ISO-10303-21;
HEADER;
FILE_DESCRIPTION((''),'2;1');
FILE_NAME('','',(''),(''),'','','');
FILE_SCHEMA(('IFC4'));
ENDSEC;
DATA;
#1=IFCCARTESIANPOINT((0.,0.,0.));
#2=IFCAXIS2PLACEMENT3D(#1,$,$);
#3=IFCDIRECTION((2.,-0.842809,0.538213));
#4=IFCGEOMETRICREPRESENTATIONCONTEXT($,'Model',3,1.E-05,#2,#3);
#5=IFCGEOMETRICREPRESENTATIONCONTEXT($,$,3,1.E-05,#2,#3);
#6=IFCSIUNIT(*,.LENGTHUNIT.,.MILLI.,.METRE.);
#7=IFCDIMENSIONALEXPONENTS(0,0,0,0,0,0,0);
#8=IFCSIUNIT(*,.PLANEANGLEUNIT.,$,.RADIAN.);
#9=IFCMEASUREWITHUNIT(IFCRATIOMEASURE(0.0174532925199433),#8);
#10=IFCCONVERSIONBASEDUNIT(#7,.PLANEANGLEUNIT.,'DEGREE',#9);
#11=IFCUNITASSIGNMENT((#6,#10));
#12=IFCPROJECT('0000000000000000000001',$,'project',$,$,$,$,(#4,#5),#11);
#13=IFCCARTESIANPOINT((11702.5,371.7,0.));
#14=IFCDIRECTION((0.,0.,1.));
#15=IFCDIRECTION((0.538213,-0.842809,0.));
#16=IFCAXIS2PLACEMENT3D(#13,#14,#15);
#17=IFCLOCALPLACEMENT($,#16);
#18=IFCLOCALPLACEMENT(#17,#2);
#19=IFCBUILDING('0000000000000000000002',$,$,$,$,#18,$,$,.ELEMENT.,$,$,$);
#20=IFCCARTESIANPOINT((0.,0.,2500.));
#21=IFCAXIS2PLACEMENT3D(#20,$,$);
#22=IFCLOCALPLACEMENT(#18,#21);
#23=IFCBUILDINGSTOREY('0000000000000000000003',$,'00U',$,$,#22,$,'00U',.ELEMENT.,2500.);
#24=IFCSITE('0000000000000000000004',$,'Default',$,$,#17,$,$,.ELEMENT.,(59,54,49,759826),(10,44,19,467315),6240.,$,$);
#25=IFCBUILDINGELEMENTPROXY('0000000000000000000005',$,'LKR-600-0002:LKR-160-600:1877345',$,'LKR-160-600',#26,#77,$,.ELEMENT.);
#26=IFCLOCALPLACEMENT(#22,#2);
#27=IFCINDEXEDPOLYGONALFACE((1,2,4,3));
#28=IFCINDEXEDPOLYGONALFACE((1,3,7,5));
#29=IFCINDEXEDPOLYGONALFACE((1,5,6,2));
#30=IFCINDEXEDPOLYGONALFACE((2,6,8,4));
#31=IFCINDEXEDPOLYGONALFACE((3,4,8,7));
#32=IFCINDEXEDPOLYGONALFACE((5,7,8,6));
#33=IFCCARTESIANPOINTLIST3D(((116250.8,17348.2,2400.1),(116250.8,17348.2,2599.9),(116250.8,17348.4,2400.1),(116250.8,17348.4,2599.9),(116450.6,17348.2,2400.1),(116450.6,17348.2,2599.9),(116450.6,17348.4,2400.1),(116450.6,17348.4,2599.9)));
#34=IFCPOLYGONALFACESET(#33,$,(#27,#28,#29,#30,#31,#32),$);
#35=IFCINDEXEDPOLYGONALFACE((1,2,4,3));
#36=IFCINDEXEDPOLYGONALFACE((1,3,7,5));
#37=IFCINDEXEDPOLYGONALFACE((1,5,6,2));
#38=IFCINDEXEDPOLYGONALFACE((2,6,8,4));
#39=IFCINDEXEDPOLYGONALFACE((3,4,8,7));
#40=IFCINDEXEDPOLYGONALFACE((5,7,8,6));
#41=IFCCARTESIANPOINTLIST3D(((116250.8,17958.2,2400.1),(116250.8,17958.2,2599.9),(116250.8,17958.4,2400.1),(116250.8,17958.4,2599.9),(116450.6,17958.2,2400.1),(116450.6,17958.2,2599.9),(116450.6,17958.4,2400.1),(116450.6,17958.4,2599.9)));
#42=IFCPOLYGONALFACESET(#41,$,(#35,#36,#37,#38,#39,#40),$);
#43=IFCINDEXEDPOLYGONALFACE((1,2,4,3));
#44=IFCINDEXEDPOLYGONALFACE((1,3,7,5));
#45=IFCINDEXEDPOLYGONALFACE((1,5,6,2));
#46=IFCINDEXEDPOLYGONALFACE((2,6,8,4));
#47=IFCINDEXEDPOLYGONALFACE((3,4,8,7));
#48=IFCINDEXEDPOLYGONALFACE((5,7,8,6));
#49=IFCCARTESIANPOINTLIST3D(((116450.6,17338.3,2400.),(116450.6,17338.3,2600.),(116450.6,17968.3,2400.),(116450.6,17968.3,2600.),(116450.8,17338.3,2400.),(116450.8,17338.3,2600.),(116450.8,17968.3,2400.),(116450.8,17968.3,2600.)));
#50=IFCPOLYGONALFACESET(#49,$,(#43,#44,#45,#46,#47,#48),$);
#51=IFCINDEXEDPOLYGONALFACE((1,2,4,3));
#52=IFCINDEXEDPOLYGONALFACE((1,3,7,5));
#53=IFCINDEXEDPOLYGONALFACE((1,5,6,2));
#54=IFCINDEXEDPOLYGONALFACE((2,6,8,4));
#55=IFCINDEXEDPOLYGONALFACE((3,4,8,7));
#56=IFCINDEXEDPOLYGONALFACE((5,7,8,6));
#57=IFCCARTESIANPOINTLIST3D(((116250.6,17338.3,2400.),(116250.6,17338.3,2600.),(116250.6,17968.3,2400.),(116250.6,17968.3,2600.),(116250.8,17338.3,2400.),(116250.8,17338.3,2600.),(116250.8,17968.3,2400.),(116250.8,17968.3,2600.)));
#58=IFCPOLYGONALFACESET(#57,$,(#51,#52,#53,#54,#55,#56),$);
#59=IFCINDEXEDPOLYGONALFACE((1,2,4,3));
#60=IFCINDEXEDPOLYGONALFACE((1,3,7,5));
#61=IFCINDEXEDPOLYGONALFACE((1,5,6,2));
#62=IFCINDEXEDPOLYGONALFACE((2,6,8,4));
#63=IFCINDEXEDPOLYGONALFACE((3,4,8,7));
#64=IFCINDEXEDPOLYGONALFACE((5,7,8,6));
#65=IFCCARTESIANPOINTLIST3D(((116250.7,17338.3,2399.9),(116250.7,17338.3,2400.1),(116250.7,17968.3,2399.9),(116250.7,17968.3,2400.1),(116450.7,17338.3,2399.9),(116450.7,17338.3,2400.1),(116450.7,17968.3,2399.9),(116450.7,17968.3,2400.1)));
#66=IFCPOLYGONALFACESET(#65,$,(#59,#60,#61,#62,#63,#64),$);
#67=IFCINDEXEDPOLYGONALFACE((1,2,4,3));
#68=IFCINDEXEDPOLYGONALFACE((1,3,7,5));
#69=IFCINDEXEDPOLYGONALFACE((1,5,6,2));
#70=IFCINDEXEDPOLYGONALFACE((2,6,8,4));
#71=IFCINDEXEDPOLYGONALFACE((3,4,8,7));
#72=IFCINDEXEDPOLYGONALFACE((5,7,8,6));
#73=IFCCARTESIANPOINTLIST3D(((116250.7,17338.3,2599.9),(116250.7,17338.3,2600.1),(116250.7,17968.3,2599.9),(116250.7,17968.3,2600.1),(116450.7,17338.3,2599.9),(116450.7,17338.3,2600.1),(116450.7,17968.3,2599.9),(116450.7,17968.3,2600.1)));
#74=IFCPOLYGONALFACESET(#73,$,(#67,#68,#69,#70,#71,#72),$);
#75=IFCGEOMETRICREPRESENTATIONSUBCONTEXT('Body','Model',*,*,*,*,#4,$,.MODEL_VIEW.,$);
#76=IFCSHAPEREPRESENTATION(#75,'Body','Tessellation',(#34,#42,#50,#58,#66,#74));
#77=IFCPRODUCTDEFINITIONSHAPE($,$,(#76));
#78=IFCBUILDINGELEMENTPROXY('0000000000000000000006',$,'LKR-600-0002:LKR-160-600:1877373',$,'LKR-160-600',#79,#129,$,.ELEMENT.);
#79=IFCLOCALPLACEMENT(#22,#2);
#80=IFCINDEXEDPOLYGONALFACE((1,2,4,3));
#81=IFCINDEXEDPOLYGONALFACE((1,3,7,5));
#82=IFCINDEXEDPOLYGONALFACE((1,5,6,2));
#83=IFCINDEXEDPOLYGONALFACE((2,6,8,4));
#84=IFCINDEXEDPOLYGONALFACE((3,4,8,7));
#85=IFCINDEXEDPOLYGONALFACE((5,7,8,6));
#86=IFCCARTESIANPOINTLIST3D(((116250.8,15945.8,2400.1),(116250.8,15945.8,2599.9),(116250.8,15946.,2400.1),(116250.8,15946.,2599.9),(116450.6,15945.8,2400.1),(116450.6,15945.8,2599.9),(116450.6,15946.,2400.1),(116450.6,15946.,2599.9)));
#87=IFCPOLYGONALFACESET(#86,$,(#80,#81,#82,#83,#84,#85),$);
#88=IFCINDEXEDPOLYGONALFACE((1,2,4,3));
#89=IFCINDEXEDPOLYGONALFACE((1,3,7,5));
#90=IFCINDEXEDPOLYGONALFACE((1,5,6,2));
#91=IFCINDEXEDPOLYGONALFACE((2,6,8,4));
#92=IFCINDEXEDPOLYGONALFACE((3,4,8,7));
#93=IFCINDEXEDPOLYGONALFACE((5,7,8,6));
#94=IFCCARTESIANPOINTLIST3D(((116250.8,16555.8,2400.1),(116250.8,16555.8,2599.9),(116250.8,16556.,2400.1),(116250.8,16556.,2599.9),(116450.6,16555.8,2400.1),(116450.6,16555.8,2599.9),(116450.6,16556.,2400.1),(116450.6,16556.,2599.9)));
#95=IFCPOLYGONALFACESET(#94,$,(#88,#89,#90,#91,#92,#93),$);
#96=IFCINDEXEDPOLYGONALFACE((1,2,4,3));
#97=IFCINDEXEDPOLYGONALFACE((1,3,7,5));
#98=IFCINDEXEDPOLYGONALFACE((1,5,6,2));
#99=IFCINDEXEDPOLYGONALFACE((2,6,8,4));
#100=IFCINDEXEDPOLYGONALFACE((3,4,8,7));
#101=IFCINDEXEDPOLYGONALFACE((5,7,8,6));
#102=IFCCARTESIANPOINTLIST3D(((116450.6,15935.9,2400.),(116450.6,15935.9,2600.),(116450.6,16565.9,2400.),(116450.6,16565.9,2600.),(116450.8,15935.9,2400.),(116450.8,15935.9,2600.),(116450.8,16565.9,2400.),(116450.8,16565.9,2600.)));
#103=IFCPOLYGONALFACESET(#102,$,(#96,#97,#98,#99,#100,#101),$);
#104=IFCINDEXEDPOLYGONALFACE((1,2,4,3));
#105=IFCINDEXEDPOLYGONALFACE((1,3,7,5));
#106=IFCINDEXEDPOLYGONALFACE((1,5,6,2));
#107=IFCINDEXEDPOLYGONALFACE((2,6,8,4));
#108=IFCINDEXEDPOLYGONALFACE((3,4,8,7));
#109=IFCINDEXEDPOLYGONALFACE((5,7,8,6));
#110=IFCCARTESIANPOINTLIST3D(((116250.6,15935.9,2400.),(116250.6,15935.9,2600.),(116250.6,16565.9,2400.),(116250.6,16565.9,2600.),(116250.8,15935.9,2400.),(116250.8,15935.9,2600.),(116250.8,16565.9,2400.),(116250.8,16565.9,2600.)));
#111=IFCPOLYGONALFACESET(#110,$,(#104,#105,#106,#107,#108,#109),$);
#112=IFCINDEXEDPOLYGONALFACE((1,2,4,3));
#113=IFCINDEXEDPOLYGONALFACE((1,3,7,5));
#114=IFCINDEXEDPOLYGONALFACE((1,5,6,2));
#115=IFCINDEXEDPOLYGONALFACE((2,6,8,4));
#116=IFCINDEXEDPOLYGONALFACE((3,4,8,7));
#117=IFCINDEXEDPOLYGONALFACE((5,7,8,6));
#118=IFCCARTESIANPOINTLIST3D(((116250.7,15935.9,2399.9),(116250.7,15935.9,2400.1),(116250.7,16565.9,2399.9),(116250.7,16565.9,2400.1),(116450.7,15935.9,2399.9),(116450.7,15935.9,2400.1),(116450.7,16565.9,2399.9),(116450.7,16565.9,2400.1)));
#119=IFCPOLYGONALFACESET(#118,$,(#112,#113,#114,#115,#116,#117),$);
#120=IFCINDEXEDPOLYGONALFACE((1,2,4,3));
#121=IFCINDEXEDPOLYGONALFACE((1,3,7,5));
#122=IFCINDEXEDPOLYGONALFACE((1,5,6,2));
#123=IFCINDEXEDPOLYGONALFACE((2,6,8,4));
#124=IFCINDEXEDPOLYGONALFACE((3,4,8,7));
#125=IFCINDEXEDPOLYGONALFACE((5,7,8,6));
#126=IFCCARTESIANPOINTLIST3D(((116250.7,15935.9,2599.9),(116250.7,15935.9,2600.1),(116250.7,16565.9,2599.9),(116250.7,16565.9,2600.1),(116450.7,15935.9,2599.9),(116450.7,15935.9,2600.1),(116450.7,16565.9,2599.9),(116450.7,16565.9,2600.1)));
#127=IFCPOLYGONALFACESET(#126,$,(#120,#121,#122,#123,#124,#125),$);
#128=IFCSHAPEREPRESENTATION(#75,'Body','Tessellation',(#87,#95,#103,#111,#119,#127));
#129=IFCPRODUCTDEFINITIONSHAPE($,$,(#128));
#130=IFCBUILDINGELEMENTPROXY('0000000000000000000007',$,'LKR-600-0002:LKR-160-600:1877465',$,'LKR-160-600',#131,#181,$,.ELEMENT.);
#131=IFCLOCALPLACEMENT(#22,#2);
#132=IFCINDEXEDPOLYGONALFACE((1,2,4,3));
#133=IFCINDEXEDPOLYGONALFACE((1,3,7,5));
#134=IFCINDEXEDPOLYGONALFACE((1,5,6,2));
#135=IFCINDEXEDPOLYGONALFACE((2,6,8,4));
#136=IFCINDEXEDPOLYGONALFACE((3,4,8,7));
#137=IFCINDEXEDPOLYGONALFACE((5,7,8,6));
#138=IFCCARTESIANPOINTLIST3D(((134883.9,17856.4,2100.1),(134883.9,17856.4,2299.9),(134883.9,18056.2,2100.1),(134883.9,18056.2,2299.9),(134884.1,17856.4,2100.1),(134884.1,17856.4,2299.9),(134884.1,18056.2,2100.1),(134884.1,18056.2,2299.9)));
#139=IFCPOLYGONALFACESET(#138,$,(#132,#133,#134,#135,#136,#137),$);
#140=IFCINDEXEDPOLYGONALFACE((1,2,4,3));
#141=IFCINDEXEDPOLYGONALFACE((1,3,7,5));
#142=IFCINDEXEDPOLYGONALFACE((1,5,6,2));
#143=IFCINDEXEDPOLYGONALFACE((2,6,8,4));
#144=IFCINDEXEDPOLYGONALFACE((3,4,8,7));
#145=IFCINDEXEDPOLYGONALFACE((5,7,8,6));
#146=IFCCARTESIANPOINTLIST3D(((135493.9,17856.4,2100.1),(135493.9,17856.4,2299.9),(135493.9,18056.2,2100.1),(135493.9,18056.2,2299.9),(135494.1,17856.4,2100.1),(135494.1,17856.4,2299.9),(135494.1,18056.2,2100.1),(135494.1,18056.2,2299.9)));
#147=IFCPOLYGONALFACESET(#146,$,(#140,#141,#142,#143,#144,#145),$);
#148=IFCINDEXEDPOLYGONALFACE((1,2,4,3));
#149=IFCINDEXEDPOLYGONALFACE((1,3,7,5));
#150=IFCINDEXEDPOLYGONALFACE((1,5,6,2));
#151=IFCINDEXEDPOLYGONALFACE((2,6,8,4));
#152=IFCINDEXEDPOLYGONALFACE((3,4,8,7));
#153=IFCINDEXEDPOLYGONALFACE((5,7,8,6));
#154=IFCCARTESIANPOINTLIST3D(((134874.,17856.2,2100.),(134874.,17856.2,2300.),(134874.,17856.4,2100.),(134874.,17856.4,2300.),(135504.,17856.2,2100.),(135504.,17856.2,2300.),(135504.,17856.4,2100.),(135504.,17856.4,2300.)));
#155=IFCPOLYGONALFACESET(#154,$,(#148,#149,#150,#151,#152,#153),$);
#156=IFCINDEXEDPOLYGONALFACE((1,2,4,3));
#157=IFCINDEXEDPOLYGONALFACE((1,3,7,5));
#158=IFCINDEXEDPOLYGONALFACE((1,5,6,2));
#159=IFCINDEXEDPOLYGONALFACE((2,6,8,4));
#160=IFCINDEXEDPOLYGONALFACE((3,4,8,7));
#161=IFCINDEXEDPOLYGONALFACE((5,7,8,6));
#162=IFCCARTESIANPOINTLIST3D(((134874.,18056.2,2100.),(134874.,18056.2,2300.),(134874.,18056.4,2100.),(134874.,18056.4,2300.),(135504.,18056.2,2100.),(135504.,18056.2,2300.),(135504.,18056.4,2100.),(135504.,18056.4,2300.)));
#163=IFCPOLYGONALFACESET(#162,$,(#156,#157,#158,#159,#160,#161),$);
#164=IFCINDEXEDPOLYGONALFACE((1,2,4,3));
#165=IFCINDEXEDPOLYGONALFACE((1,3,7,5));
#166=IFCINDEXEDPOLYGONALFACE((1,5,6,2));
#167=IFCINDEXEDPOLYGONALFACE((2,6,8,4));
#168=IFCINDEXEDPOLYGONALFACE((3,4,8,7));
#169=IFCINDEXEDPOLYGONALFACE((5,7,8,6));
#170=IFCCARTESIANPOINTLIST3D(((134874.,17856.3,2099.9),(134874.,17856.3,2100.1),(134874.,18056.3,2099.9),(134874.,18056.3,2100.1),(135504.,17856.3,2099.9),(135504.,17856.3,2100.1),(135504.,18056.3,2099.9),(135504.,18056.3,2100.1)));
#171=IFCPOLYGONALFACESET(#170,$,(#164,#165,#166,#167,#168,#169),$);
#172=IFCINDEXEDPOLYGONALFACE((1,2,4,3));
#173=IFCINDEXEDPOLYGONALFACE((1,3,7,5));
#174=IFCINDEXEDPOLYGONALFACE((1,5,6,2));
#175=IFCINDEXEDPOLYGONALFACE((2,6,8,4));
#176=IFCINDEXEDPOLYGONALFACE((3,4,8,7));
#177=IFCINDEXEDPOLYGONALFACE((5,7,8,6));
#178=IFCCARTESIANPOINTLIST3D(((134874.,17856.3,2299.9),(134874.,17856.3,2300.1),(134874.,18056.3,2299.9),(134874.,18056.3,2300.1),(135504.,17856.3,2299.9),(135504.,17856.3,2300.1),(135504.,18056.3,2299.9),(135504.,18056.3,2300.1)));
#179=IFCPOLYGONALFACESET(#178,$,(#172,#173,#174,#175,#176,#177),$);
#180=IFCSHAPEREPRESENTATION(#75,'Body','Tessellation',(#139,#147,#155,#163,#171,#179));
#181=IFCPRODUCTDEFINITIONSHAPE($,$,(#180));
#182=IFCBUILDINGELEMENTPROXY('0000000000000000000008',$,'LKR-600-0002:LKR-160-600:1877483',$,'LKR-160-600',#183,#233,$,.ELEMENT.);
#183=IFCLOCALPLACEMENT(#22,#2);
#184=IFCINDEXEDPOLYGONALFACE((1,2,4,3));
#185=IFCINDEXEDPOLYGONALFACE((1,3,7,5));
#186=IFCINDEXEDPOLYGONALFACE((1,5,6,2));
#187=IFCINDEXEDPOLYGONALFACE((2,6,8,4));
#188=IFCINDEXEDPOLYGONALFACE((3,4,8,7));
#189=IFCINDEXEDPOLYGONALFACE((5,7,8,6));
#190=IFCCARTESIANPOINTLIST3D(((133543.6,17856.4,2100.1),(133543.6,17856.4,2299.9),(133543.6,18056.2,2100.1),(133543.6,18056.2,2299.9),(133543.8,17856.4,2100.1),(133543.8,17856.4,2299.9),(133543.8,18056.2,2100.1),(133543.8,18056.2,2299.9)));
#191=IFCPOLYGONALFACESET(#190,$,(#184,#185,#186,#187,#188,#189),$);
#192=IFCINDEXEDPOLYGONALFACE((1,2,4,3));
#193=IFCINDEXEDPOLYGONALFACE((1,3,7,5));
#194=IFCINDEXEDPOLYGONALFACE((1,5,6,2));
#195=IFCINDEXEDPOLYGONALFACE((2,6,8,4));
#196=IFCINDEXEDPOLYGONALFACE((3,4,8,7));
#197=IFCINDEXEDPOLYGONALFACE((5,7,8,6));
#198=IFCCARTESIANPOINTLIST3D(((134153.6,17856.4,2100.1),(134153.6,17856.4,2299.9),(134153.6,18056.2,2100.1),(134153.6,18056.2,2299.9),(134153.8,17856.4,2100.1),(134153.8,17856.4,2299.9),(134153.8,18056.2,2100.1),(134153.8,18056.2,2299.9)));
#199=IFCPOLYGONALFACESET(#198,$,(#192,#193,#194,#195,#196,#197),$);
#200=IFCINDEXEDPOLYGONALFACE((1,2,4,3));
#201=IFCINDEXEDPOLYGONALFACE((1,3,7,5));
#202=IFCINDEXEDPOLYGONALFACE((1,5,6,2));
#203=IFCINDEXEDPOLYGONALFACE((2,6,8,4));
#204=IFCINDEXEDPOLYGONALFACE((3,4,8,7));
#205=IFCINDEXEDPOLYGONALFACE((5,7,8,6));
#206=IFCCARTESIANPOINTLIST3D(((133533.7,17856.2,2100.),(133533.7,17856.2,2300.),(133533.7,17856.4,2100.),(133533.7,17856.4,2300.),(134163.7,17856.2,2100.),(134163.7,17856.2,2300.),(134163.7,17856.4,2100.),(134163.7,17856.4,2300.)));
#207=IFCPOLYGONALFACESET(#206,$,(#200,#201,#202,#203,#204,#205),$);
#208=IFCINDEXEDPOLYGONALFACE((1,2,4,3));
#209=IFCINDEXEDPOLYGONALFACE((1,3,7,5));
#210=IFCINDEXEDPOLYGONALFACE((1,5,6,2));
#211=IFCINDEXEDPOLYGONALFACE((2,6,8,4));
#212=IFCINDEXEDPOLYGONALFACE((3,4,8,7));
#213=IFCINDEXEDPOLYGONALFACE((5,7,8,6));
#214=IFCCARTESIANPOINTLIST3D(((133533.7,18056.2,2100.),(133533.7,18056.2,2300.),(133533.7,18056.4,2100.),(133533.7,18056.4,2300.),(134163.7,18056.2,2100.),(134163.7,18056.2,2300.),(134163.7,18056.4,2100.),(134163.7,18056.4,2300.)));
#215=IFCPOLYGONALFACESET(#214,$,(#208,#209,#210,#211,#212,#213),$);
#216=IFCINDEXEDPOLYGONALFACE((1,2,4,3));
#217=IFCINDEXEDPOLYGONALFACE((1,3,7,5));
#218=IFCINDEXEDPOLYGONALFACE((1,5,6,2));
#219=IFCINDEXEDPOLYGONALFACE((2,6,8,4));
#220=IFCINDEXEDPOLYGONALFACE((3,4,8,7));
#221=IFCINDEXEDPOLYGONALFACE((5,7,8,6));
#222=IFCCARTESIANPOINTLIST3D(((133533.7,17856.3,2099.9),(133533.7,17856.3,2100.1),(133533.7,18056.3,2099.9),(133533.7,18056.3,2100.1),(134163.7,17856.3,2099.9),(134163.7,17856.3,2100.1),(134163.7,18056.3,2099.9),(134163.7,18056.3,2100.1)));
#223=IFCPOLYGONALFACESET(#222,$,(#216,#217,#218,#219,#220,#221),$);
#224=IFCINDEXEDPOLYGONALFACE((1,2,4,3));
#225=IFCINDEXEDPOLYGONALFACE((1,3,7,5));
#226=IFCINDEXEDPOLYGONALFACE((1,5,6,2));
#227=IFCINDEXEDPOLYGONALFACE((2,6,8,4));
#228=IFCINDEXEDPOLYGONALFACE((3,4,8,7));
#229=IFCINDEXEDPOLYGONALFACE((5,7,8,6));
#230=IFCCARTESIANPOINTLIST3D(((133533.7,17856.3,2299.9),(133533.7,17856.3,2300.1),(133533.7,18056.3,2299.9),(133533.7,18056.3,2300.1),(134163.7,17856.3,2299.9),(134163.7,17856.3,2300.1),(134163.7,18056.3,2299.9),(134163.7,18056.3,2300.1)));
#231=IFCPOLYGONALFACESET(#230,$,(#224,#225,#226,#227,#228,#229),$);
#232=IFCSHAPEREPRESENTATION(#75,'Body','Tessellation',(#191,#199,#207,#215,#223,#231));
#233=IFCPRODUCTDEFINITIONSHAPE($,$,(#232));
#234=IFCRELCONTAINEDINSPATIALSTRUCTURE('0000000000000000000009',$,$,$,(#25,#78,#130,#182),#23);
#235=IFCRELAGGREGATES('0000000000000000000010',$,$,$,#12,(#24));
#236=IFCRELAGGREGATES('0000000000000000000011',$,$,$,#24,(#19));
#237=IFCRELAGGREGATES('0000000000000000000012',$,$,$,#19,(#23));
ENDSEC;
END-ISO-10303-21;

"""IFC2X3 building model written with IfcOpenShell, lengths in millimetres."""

from ifc_helpers import new_model, entity, si_unit, converted_unit, direction, frame, frame_2d, origin, origin_2d_with_axis, place, context, subcontext, project, spatial, rectangle, extrude, source, transform, mapped, element, save


model = new_model("IFC2X3")

# Units and contexts
model_context = context("Model", 3, precision=1e-05, world=origin(), true_north=direction((2.0, -0.842809, 0.538213)))
context_of_model = context(None, 3, precision=1e-05, world=origin(), true_north=direction((2.0, -0.842809, 0.538213)))
body_context = subcontext(model_context, "Body", "Model", "MODEL_VIEW")
ifc_project = project(units=[si_unit("LENGTHUNIT", "METRE", prefix="MILLI"), converted_unit("PLANEANGLEUNIT", "DEGREE", entity("IfcRatioMeasure", 0.0174532925199433), si_unit("PLANEANGLEUNIT", "RADIAN"), dimensions=[0, 0, 0, 0, 0, 0, 0])], contexts=[model_context, context_of_model])

# Site, building, storey
site_placement = place(None, frame((11702.5, 371.7, 0.0), z_axis=(0.0, 0.0, 1.0), x_axis=(0.538213, -0.842809, 0.0)))
site = spatial("IfcSite", under=ifc_project, at=site_placement, Name="Default", CompositionType="ELEMENT", RefLatitude=(59, 54, 49, 759826), RefLongitude=(10, 44, 19, 467315), RefElevation=6240.0)
building_placement = place(site_placement, origin())
building = spatial("IfcBuilding", under=site, at=building_placement, CompositionType="ELEMENT")
storey_placement = place(building_placement, frame((0.0, 0.0, 2500.0)))
storey = spatial("IfcBuildingStorey", under=building, at=storey_placement, Name="00U", LongName="00U", CompositionType="ELEMENT", Elevation=2500.0)

# Building element proxies
shared_shape_1 = source(origin(), body_context, "Body", "SweptSolid", [
    extrude(rectangle(XDim=0.2, YDim=199.8, at=frame_2d((0.0, 0.0), x_axis=(1.0, 0.0))), frame((305.0, 0.0, -99.9)), (0.0, 0.0, 1.0), 199.8),
    extrude(rectangle(XDim=0.2, YDim=199.8, at=frame_2d((0.0, 0.0), x_axis=(1.0, 0.0))), frame((-305.0, 0.0, -99.9)), (0.0, 0.0, 1.0), 199.8),
    extrude(rectangle(XDim=0.2, YDim=630.0, at=frame_2d((0.0, 0.0), x_axis=(1.0, 0.0))), frame((0.0, 100.0, -100.0), z_axis=(0.0, 0.0, 1.0), x_axis=(0.0, 1.0, 0.0)), (0.0, 0.0, 1.0), 200.0),
    extrude(rectangle(XDim=0.2, YDim=630.0, at=frame_2d((0.0, 0.0), x_axis=(1.0, 0.0))), frame((0.0, -100.0, -100.0), z_axis=(0.0, 0.0, 1.0), x_axis=(0.0, 1.0, 0.0)), (0.0, 0.0, 1.0), 200.0),
    extrude(rectangle(XDim=200.0, YDim=630.0, at=origin_2d_with_axis()), frame((0.0, 0.0, -100.1), z_axis=(0.0, 0.0, 1.0), x_axis=(0.0, -1.0, 0.0)), (0.0, 0.0, 1.0), 0.2),
    extrude(rectangle(XDim=200.0, YDim=630.0, at=origin_2d_with_axis()), frame((0.0, 0.0, 99.9), z_axis=(0.0, 0.0, 1.0), x_axis=(0.0, -1.0, 0.0)), (0.0, 0.0, 1.0), 0.2),
])
for number, where, z_axis, x_axis, name in (
    (1, (116350.7, 17653.3, 2500.0), (0.0, 0.0, 1.0), (0.0, -1.0, 0.0), "LKR-600-0002:LKR-160-600:1877345"),
    (2, (116350.7, 16250.9, 2500.0), (0.0, 0.0, 1.0), (0.0, -1.0, 0.0), "LKR-600-0002:LKR-160-600:1877373"),
    (3, (135189.0, 17956.3, 2200.0), (0.0, 0.0, 1.0), (-1.0, 0.0, 0.0), "LKR-600-0002:LKR-160-600:1877465"),
    (4, (133848.7, 17956.3, 2200.0), (0.0, 0.0, 1.0), (-1.0, 0.0, 0.0), "LKR-600-0002:LKR-160-600:1877483"),
):
    element("IfcBuildingElementProxy", number, at=place(storey_placement, frame(where, z_axis=z_axis, x_axis=x_axis)), inside=storey, Name=name, ObjectType="LKR-160-600", CompositionType="ELEMENT", context=body_context, shape_type="MappedRepresentation", body=[
        mapped(shared_shape_1, transform((0.0, 0.0, 0.0), scale=1.0)),
    ])

save(model, "model.ifc")
